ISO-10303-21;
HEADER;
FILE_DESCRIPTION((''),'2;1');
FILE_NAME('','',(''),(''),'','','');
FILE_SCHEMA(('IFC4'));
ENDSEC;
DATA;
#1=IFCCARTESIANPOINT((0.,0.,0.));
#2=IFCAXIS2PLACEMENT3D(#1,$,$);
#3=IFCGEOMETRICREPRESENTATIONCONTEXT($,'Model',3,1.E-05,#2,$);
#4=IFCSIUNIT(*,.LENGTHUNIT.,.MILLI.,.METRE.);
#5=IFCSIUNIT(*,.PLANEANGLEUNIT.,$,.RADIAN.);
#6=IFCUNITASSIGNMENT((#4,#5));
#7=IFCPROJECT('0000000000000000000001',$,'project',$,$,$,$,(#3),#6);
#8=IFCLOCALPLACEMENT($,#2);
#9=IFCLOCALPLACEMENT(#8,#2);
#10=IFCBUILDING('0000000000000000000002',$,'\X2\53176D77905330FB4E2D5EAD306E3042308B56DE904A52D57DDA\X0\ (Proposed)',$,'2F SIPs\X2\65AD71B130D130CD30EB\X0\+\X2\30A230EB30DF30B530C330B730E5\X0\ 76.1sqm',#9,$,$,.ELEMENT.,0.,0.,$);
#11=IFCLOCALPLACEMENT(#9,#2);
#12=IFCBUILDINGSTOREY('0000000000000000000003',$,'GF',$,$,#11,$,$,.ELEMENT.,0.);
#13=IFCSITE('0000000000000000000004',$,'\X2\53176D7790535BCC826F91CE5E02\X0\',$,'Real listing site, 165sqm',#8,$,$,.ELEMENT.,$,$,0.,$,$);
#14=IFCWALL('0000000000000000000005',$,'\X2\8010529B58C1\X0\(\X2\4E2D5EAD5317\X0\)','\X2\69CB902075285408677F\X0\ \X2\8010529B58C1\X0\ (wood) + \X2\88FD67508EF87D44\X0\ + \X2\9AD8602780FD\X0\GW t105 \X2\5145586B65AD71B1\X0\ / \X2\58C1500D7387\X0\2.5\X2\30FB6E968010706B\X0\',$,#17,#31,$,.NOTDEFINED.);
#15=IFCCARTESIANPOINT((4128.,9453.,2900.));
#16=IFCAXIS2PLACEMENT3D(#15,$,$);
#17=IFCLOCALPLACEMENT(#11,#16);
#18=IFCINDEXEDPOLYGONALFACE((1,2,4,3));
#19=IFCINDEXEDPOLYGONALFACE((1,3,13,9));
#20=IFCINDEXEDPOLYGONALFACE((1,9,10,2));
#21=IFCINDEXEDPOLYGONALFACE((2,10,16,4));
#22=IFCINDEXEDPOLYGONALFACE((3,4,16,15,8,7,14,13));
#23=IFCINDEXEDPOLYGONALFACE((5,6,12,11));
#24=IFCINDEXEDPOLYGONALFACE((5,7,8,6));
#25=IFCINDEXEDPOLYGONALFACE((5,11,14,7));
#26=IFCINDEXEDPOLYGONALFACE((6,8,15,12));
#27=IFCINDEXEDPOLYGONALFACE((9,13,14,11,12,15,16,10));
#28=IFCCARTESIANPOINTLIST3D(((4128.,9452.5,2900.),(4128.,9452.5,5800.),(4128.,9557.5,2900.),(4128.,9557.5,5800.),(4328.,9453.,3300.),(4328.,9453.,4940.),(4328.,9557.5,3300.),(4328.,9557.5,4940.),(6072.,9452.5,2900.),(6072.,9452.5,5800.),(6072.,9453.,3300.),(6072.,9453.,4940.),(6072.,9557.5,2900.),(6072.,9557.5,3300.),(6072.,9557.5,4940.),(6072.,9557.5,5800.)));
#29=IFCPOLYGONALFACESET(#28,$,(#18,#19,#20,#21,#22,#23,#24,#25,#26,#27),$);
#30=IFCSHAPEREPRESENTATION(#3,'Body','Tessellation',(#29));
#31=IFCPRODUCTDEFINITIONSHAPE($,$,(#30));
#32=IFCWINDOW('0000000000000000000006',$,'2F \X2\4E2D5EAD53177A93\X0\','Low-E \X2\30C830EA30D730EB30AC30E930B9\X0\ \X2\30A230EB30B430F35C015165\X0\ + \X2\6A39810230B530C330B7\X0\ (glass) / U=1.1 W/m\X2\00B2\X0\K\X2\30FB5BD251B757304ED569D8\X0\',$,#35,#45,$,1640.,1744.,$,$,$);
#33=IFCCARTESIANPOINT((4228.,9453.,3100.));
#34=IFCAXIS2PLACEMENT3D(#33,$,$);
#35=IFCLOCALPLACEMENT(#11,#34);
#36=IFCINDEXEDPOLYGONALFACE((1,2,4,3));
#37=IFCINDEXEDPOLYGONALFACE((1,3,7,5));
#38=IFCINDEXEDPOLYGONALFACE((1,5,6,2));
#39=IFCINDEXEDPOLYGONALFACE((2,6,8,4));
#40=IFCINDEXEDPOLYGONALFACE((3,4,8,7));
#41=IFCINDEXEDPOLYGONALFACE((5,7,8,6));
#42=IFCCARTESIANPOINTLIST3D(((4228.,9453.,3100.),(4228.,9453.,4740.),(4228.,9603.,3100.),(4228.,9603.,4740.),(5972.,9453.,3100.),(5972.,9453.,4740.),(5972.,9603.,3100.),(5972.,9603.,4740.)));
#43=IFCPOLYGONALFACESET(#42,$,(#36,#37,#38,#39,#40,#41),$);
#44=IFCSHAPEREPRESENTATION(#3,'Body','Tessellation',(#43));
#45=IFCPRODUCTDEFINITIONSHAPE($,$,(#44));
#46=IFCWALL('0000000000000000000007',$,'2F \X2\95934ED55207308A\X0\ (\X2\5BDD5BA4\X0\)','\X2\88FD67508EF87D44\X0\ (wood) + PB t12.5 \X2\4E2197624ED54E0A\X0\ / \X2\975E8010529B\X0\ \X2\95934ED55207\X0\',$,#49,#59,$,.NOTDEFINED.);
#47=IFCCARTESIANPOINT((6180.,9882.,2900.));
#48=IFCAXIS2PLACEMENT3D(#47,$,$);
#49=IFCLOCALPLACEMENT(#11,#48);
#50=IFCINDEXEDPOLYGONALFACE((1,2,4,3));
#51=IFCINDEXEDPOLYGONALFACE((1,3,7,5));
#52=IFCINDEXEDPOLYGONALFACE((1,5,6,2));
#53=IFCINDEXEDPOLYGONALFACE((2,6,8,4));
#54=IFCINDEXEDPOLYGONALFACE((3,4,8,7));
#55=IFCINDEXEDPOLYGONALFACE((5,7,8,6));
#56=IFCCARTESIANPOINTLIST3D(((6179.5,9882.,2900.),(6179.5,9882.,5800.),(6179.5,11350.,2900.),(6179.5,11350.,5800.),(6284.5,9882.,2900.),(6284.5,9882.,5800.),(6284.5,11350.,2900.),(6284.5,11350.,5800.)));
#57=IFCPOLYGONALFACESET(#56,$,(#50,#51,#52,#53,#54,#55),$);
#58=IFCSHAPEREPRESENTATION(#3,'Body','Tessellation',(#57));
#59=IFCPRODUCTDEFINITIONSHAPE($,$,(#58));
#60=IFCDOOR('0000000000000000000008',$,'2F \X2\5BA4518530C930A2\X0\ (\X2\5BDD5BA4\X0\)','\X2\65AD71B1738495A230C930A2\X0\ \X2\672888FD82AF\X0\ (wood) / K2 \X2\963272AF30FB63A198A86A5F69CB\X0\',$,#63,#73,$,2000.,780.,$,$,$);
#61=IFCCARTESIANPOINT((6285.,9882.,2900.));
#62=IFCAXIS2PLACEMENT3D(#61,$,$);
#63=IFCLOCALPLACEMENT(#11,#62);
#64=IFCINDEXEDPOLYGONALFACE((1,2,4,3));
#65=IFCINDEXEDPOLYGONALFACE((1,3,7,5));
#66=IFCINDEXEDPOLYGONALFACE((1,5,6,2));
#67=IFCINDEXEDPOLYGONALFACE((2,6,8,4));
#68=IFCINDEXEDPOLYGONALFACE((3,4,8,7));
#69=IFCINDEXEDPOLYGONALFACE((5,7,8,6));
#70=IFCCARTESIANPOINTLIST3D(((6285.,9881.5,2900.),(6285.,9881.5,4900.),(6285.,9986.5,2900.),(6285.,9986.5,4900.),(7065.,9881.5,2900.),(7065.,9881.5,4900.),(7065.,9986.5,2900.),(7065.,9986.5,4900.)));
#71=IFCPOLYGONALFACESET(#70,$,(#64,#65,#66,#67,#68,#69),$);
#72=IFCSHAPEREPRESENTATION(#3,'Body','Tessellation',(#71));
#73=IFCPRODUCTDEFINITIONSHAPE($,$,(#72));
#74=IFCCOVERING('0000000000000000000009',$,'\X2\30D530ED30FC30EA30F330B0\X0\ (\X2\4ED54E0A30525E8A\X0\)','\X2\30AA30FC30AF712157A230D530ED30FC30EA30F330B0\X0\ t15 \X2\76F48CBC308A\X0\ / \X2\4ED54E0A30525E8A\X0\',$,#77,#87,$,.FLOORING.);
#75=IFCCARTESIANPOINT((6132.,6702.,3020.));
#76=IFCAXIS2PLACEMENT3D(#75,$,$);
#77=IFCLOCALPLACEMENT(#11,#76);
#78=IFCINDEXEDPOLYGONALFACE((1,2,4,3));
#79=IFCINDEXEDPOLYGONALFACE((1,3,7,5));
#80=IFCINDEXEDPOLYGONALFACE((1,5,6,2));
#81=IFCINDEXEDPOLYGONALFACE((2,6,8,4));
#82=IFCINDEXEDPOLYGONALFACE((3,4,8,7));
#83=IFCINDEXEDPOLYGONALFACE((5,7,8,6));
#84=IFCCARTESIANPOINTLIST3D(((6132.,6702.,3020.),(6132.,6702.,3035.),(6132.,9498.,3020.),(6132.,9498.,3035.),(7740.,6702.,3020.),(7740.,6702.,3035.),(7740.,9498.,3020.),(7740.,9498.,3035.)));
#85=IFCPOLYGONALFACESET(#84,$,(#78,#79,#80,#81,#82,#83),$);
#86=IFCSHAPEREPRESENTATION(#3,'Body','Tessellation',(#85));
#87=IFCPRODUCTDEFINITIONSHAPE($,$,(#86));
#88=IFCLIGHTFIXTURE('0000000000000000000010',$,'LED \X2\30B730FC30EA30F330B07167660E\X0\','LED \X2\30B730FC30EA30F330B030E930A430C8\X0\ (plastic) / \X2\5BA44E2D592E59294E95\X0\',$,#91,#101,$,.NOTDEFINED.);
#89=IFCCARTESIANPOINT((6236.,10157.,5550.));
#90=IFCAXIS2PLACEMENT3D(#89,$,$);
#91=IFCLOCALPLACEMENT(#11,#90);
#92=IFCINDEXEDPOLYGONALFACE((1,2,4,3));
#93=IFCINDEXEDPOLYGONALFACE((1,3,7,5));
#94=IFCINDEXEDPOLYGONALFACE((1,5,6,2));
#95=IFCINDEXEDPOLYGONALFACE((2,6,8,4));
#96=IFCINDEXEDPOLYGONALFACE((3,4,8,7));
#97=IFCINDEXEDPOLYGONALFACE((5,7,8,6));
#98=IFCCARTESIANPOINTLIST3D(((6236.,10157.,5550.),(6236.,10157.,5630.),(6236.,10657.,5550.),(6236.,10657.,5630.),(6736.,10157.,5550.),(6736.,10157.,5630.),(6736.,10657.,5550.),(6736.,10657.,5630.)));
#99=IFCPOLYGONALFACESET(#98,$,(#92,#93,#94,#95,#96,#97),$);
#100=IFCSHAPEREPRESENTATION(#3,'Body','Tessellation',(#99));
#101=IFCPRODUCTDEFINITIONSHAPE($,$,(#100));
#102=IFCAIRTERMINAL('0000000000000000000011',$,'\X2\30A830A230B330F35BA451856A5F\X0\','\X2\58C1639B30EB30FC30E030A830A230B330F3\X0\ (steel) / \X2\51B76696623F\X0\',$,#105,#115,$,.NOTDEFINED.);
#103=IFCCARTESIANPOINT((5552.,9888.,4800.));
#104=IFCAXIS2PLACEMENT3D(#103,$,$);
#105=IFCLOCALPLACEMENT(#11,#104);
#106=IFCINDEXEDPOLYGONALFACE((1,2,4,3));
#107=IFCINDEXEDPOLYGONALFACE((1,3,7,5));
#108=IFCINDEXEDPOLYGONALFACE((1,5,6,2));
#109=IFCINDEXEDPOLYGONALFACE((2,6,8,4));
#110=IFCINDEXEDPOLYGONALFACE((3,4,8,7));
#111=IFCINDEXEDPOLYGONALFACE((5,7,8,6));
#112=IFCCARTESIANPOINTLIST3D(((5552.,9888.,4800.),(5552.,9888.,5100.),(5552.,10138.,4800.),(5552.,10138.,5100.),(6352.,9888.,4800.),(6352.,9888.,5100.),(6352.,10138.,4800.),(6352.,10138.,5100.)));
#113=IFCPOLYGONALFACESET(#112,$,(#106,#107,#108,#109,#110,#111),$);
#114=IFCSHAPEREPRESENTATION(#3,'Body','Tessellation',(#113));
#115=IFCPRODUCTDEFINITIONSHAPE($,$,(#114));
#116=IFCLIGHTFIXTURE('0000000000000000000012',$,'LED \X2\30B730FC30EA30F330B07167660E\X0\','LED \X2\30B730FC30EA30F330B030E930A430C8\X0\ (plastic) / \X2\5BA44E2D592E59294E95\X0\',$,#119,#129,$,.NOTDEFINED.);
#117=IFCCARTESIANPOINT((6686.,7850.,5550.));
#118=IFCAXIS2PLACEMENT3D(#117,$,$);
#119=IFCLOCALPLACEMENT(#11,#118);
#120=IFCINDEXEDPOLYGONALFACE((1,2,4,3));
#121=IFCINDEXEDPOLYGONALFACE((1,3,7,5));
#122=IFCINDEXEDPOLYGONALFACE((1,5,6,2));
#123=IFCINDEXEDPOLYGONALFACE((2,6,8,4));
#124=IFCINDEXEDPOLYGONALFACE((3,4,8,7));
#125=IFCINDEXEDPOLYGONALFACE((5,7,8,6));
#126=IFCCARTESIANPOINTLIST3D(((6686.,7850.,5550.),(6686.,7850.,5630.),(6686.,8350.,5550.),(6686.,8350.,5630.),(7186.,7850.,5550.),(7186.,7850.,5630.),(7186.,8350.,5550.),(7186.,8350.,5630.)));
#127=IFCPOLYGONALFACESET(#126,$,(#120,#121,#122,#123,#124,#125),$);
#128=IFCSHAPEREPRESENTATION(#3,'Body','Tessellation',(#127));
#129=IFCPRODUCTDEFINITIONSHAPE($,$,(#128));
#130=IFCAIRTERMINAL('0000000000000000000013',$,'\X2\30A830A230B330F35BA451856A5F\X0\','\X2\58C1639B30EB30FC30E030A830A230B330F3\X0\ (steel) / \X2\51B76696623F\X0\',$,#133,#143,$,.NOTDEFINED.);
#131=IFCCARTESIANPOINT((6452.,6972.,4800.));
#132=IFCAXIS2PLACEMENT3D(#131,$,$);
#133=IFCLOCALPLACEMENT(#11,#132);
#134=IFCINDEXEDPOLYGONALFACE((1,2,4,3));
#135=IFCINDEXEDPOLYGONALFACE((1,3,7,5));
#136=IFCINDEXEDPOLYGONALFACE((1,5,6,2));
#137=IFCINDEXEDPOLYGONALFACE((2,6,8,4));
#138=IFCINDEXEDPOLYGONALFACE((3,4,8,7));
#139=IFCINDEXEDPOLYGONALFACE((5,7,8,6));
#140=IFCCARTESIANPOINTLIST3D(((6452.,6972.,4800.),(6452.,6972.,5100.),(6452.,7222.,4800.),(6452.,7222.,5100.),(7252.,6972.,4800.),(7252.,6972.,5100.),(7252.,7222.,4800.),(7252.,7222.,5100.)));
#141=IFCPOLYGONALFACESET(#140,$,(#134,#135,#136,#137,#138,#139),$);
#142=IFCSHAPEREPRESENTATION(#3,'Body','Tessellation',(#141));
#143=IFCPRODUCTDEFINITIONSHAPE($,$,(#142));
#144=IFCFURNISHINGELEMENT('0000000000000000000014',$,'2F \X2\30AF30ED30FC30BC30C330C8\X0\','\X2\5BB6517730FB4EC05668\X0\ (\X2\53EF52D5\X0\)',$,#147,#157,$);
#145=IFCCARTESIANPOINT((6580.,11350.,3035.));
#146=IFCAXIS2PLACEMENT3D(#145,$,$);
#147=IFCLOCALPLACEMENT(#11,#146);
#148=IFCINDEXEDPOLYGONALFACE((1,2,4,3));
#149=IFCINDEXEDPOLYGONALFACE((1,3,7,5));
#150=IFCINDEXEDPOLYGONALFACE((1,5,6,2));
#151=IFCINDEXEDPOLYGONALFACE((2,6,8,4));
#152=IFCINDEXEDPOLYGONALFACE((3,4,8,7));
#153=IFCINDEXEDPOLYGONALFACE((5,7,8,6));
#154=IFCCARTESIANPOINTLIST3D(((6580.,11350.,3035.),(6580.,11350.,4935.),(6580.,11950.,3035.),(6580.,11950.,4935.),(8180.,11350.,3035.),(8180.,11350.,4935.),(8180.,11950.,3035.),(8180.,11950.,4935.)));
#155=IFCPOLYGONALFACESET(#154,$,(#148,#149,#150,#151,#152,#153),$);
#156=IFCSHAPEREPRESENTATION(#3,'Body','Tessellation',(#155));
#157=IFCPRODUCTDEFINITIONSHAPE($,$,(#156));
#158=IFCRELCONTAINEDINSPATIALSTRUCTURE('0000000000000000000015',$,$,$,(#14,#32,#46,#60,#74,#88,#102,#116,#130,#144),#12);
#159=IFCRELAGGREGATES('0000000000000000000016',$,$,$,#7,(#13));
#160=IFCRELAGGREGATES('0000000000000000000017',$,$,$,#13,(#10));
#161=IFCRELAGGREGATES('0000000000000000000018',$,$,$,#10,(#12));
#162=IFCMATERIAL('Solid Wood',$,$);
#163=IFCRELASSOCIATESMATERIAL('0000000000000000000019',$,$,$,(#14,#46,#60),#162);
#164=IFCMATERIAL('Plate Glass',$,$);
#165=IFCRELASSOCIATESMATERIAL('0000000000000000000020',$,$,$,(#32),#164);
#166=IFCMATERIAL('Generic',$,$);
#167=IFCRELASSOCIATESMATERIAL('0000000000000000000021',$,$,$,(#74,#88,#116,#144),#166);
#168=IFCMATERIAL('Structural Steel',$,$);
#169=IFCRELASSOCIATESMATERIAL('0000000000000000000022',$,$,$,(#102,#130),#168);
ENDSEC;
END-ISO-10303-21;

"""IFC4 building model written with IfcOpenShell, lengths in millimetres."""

from ifc_helpers import new_model, si_unit, frame, frame_2d, origin, place, context, project, spatial, rectangle, extrude, material, element, fill, save


model = new_model("IFC4")

# Units and contexts
model_context = context("Model", 3, precision=1e-05, world=origin())
ifc_project = project(units=[si_unit("LENGTHUNIT", "METRE", prefix="MILLI"), si_unit("PLANEANGLEUNIT", "RADIAN")], contexts=[model_context])

# Site, building, storey
site_placement = place(None, origin())
site = spatial("IfcSite", under=ifc_project, at=site_placement, Name="北海道富良野市", ObjectType="Real listing site, 165sqm", CompositionType="ELEMENT", RefElevation=0.0)
building_placement = place(site_placement, origin())
building = spatial("IfcBuilding", under=site, at=building_placement, Name="北海道・中庭のある回遊動線 (Proposed)", ObjectType="2F SIPs断熱パネル+アルミサッシュ 76.1sqm", CompositionType="ELEMENT", ElevationOfRefHeight=0.0, ElevationOfTerrain=0.0)
storey_placement = place(building_placement, origin())
storey = spatial("IfcBuildingStorey", under=building, at=storey_placement, Name="GF", CompositionType="ELEMENT", Elevation=0.0)

# Shared definitions
ifc_material_1 = material(Name="Solid Wood")

# Wall, opening, window
wall_1_placement = place(storey_placement, frame((4128.0, 9453.0, 2900.0)))
wall_1 = element("IfcWall", 1, at=wall_1_placement, inside=storey, material=ifc_material_1, Name="耐力壁(中庭北)", Description="構造用合板 耐力壁 (wood) + 製材軸組 + 高性能GW t105 充填断熱 / 壁倍率2.5・準耐火", PredefinedType="NOTDEFINED", context=model_context, shape_type="SweptSolid", body=[
    extrude(rectangle(XDim=1944.0, YDim=105.0, at=frame_2d((972.0, 52.0))), frame((4128.0, 9453.0, 2900.0)), (0.0, 0.0, 1.0), 2900.0),
])
opening_placement = place(storey_placement, frame((4228.0, 9453.0, 3100.0)))
opening = element("IfcOpeningElement", 2, at=opening_placement, cuts=wall_1, PredefinedType="NOTDEFINED", context=model_context, shape_type="SweptSolid", body=[
    extrude(rectangle(XDim=1744.0, YDim=150.0, at=frame_2d((872.0, 75.0))), frame((4228.0, 9453.0, 3100.0)), (0.0, 0.0, 1.0), 1640.0),
])
ifc_material_2 = material(Name="Plate Glass")
window_placement = place(storey_placement, frame((4228.0, 9453.0, 3100.0)))
window = element("IfcWindow", 3, at=window_placement, inside=storey, material=ifc_material_2, Name="2F 中庭北窓", Description="Low-E トリプルガラス アルゴン封入 + 樹脂サッシ (glass) / U=1.1 W/m²K・寒冷地仕様", OverallHeight=1640.0, OverallWidth=1744.0, context=model_context, shape_type="SweptSolid", body=[
    extrude(rectangle(XDim=1744.0, YDim=150.0, at=frame_2d((872.0, 75.0))), frame((4228.0, 9453.0, 3100.0)), (0.0, 0.0, 1.0), 1640.0),
])
fill(opening, window)

# Wall
wall_2_placement = place(storey_placement, frame((6180.0, 9882.0, 2900.0)))
element("IfcWall", 4, at=wall_2_placement, inside=storey, material=ifc_material_1, Name="2F 間仕切り (寝室)", Description="製材軸組 (wood) + PB t12.5 両面仕上 / 非耐力 間仕切", PredefinedType="NOTDEFINED", context=model_context, shape_type="SweptSolid", body=[
    extrude(rectangle(XDim=105.0, YDim=1468.0, at=frame_2d((52.0, 734.0))), frame((6180.0, 9882.0, 2900.0)), (0.0, 0.0, 1.0), 2900.0),
])

# Door
door_placement = place(storey_placement, frame((6285.0, 9882.0, 2900.0)))
element("IfcDoor", 5, at=door_placement, inside=storey, material=ifc_material_1, Name="2F 室内ドア (寝室)", Description="断熱玄関ドア 木製芯 (wood) / K2 防犯・採風機構", OverallHeight=2000.0, OverallWidth=780.0, context=model_context, shape_type="SweptSolid", body=[
    extrude(rectangle(XDim=780.0, YDim=105.0, at=frame_2d((390.0, 52.0))), frame((6285.0, 9882.0, 2900.0)), (0.0, 0.0, 1.0), 2000.0),
])

# Covering
ifc_material_3 = material(Name="Generic")
covering_placement = place(storey_placement, frame((6132.0, 6702.0, 3020.0)))
element("IfcCovering", 6, at=covering_placement, inside=storey, material=ifc_material_3, Name="フローリング (仕上げ床)", Description="オーク無垢フローリング t15 直貼り / 仕上げ床", PredefinedType="FLOORING", context=model_context, shape_type="SweptSolid", body=[
    extrude(rectangle(XDim=1608.0, YDim=2796.0, at=frame_2d((804.0, 1398.0))), frame((6132.0, 6702.0, 3020.0)), (0.0, 0.0, 1.0), 15.0),
])

# Light fixture
light_fixture_1_placement = place(storey_placement, frame((6236.0, 10157.0, 5550.0)))
element("IfcLightFixture", 7, at=light_fixture_1_placement, inside=storey, material=ifc_material_3, Name="LED シーリング照明", Description="LED シーリングライト (plastic) / 室中央天井", PredefinedType="NOTDEFINED", context=model_context, shape_type="SweptSolid", body=[
    extrude(rectangle(XDim=500.0, YDim=500.0, at=frame_2d((250.0, 250.0))), frame((6236.0, 10157.0, 5550.0)), (0.0, 0.0, 1.0), 80.0),
])

# Air terminal
ifc_material_4 = material(Name="Structural Steel")
air_terminal_1_placement = place(storey_placement, frame((5552.0, 9888.0, 4800.0)))
element("IfcAirTerminal", 8, at=air_terminal_1_placement, inside=storey, material=ifc_material_4, Name="エアコン室内機", Description="壁掛ルームエアコン (steel) / 冷暖房", PredefinedType="NOTDEFINED", context=model_context, shape_type="SweptSolid", body=[
    extrude(rectangle(XDim=800.0, YDim=250.0, at=frame_2d((400.0, 125.0))), frame((5552.0, 9888.0, 4800.0)), (0.0, 0.0, 1.0), 300.0),
])

# Light fixture
light_fixture_2_placement = place(storey_placement, frame((6686.0, 7850.0, 5550.0)))
element("IfcLightFixture", 9, at=light_fixture_2_placement, inside=storey, material=ifc_material_3, Name="LED シーリング照明", Description="LED シーリングライト (plastic) / 室中央天井", PredefinedType="NOTDEFINED", context=model_context, shape_type="SweptSolid", body=[
    extrude(rectangle(XDim=500.0, YDim=500.0, at=frame_2d((250.0, 250.0))), frame((6686.0, 7850.0, 5550.0)), (0.0, 0.0, 1.0), 80.0),
])

# Air terminal
air_terminal_2_placement = place(storey_placement, frame((6452.0, 6972.0, 4800.0)))
element("IfcAirTerminal", 10, at=air_terminal_2_placement, inside=storey, material=ifc_material_4, Name="エアコン室内機", Description="壁掛ルームエアコン (steel) / 冷暖房", PredefinedType="NOTDEFINED", context=model_context, shape_type="SweptSolid", body=[
    extrude(rectangle(XDim=800.0, YDim=250.0, at=frame_2d((400.0, 125.0))), frame((6452.0, 6972.0, 4800.0)), (0.0, 0.0, 1.0), 300.0),
])

# Furnishing element
furnishing_placement = place(storey_placement, frame((6580.0, 11350.0, 3035.0)))
element("IfcFurnishingElement", 11, at=furnishing_placement, inside=storey, material=ifc_material_3, Name="2F クローゼット", Description="家具・什器 (可動)", context=model_context, shape_type="SweptSolid", body=[
    extrude(rectangle(XDim=1600.0, YDim=600.0, at=frame_2d((800.0, 300.0))), frame((6580.0, 11350.0, 3035.0)), (0.0, 0.0, 1.0), 1900.0),
])

save(model, "model.ifc")
